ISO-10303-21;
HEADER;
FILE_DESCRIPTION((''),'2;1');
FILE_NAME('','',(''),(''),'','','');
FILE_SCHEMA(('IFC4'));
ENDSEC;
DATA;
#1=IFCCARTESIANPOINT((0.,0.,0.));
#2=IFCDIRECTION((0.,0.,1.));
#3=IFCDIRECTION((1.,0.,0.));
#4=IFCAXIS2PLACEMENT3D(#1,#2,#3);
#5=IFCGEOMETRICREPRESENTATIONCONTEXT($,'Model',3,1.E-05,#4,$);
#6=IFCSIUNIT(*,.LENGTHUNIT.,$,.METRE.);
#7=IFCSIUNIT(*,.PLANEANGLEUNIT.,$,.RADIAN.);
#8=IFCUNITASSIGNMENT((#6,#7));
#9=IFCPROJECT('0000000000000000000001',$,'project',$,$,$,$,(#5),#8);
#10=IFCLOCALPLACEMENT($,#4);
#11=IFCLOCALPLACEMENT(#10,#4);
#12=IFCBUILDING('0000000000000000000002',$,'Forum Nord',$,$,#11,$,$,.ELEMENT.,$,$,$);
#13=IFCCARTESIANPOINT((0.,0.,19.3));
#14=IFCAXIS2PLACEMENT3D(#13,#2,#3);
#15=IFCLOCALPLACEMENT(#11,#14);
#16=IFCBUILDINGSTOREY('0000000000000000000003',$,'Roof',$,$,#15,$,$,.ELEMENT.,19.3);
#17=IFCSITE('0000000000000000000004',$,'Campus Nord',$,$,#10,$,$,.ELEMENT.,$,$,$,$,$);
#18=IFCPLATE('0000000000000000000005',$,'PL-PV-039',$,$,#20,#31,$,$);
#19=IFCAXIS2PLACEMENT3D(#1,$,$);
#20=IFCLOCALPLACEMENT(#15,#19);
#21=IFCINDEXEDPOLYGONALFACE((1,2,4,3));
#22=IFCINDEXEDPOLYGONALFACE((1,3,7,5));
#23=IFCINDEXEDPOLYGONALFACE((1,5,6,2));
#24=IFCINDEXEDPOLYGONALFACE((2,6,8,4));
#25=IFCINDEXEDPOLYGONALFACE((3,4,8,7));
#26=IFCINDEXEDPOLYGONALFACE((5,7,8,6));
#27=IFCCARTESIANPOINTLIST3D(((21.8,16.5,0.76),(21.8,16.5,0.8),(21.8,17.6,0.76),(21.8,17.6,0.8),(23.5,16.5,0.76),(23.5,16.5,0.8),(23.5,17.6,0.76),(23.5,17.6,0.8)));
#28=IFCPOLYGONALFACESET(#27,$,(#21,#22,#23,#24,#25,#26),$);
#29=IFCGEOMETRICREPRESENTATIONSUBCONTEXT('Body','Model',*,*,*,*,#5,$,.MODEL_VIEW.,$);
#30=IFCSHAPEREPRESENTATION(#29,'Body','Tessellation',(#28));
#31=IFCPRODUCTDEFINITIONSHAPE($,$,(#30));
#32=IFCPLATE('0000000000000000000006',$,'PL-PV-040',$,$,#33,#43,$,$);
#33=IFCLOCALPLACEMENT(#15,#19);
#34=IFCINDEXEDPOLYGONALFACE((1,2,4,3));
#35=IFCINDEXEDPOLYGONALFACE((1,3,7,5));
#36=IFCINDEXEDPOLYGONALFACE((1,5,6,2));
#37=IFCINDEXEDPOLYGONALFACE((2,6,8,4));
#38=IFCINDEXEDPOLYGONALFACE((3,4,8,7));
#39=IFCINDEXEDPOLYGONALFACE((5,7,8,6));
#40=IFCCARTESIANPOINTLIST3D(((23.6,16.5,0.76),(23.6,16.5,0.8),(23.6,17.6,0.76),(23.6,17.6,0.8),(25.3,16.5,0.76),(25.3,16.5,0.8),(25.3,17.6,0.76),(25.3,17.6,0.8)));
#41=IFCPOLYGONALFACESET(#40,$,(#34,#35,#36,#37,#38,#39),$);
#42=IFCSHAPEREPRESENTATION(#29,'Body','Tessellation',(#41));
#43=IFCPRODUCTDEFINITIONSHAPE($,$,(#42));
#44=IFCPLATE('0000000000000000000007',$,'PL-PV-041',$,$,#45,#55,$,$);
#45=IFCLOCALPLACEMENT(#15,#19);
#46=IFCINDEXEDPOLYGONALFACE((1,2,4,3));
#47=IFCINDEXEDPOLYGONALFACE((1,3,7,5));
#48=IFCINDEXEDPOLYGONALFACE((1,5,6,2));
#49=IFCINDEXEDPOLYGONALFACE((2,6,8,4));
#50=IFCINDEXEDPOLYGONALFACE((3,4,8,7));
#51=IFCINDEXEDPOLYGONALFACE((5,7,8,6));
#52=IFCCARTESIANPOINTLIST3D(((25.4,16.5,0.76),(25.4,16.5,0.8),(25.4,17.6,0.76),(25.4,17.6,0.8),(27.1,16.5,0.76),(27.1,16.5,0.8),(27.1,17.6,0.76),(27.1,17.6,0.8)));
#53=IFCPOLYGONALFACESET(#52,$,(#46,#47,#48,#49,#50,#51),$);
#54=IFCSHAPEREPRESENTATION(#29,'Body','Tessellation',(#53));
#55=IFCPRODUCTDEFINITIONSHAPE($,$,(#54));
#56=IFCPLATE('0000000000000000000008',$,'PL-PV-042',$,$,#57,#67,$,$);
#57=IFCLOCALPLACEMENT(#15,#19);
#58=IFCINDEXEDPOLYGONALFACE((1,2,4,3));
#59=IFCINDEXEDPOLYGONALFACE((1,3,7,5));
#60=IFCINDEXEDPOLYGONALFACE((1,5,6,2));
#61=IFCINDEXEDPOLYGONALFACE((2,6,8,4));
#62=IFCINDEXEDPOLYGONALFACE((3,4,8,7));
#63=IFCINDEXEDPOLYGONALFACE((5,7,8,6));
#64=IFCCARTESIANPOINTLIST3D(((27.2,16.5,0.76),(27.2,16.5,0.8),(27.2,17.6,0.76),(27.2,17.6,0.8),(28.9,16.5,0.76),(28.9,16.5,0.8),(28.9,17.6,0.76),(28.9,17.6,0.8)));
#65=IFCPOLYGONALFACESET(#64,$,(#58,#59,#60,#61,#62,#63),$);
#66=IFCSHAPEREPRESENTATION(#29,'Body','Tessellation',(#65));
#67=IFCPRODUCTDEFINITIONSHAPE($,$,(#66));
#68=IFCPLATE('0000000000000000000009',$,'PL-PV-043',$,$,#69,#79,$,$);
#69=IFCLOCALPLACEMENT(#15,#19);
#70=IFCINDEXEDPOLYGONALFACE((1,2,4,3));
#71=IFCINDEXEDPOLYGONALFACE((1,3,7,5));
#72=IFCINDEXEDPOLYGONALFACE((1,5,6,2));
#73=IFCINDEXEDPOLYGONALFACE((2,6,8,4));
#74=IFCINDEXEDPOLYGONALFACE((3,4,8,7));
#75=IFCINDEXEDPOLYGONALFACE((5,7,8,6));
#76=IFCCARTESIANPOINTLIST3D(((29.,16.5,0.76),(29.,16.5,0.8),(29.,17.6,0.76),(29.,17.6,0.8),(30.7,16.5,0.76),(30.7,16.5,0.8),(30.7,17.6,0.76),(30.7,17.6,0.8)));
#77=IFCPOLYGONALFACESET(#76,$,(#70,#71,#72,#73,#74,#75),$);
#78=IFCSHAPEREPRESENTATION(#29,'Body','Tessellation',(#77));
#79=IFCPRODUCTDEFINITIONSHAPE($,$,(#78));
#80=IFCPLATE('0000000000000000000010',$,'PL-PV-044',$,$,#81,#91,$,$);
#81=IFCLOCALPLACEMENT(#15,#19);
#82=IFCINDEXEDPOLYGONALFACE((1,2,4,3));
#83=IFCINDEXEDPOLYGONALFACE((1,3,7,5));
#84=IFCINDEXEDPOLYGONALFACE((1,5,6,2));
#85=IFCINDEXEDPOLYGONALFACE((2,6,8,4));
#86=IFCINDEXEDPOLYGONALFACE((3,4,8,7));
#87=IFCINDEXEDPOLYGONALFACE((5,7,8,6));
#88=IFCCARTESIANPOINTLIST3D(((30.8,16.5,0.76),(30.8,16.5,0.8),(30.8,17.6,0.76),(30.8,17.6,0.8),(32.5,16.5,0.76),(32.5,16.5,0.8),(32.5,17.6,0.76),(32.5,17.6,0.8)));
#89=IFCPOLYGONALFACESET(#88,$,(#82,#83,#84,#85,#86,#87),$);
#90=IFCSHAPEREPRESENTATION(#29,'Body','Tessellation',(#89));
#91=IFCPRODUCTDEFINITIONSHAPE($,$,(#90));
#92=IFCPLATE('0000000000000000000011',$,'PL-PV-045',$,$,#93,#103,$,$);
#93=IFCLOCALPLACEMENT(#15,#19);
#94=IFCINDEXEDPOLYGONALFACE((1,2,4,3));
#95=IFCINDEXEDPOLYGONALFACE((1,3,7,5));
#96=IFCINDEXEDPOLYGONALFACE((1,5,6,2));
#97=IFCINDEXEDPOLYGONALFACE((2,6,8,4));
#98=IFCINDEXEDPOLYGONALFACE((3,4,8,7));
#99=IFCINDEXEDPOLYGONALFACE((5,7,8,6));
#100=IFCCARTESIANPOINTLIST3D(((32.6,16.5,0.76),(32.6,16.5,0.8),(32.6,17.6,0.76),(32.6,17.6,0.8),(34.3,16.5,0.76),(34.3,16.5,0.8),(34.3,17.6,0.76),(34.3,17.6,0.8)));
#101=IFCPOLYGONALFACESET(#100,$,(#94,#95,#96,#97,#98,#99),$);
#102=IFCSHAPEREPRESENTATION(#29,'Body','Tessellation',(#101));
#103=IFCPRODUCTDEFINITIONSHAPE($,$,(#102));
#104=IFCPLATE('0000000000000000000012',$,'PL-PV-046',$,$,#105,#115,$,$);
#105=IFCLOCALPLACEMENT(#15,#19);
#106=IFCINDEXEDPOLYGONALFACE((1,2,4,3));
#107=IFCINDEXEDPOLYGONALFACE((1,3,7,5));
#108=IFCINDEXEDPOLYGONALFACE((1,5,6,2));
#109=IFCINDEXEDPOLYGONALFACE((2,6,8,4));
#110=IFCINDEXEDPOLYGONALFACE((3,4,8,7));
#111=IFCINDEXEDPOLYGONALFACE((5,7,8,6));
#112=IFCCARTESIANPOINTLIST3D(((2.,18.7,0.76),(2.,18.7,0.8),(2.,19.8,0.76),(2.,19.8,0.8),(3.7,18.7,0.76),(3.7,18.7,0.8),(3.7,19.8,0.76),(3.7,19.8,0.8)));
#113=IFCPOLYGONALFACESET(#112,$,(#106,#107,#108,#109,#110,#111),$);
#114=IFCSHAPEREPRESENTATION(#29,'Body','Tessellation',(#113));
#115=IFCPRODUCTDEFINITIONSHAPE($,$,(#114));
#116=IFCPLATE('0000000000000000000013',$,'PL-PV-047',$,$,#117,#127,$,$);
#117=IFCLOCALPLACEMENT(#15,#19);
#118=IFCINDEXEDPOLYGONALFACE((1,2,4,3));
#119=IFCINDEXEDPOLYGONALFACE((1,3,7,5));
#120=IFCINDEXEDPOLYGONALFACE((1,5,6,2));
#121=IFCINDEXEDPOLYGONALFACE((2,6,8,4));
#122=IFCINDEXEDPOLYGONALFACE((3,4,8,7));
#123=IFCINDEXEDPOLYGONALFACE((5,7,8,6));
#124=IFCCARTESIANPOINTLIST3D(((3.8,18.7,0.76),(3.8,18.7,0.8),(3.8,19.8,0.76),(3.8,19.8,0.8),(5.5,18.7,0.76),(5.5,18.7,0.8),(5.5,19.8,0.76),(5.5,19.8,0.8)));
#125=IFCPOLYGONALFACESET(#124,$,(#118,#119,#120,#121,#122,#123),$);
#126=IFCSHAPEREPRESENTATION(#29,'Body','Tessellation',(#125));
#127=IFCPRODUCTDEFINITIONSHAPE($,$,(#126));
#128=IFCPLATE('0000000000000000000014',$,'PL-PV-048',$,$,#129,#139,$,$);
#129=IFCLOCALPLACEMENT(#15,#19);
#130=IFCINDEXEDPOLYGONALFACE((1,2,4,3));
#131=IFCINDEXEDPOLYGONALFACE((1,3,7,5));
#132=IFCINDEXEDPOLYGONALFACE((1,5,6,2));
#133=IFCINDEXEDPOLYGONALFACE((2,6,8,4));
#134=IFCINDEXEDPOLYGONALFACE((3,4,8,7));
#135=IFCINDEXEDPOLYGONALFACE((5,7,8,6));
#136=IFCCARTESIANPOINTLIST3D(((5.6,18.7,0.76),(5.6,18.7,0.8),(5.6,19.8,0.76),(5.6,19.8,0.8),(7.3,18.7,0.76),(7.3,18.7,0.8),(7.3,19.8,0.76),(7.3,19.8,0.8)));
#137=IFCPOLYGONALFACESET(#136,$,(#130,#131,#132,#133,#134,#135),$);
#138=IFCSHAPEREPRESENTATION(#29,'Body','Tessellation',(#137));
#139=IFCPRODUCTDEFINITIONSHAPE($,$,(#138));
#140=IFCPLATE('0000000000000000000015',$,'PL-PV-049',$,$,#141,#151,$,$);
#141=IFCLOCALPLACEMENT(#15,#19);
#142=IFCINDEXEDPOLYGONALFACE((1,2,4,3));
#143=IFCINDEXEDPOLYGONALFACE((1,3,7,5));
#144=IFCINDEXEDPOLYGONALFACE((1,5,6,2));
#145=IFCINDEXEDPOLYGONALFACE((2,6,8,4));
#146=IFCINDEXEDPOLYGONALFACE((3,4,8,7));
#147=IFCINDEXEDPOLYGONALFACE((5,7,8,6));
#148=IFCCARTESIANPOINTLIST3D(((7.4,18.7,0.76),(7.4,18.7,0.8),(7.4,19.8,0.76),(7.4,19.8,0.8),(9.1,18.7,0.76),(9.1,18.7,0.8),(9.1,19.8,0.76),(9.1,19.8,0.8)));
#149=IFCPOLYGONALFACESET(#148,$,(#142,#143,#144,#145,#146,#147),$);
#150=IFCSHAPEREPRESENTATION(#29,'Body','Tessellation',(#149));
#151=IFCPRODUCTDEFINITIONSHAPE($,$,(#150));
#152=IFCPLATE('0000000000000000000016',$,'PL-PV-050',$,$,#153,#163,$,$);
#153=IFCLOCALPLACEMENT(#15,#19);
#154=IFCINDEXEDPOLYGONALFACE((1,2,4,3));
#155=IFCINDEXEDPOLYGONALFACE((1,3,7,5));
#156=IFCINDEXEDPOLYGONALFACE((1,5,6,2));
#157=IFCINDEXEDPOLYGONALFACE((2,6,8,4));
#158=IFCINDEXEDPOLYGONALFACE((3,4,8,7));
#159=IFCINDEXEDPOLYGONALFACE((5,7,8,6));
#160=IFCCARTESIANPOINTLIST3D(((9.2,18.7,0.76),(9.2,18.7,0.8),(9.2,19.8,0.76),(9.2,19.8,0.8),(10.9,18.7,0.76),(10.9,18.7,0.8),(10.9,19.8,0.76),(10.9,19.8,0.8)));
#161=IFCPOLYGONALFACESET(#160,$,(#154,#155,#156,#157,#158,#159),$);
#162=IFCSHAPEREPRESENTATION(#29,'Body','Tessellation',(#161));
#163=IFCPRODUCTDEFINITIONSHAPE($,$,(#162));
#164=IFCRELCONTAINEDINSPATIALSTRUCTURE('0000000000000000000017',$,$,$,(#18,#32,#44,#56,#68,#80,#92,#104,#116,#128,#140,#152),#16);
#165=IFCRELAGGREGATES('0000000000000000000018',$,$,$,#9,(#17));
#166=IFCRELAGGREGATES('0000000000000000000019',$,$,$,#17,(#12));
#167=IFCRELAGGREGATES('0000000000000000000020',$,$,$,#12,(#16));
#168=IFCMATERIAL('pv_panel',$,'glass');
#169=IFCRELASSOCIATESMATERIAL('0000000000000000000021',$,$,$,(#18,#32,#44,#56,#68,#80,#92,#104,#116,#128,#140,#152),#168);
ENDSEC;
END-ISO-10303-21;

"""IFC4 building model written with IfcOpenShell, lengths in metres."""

from ifc_helpers import new_model, si_unit, frame, origin_with_axes, place, context, subcontext, project, spatial, polyline, outline, extrude, material, element, save


model = new_model("IFC4")

# Units and contexts
model_context = context("Model", 3, precision=1e-05, world=origin_with_axes())
body_context = subcontext(model_context, "Body", "Model", "MODEL_VIEW")
ifc_project = project(units=[si_unit("LENGTHUNIT", "METRE"), si_unit("PLANEANGLEUNIT", "RADIAN")], contexts=[model_context])

# Site, building, storey
site_placement = place(None, origin_with_axes())
site = spatial("IfcSite", under=ifc_project, at=site_placement, Name="Campus Nord", CompositionType="ELEMENT")
building_placement = place(site_placement, origin_with_axes())
building = spatial("IfcBuilding", under=site, at=building_placement, Name="Forum Nord", CompositionType="ELEMENT")
storey_placement = place(building_placement, frame((0.0, 0.0, 19.3), z_axis=(0.0, 0.0, 1.0), x_axis=(1.0, 0.0, 0.0)))
storey = spatial("IfcBuildingStorey", under=building, at=storey_placement, Name="Roof", CompositionType="ELEMENT", Elevation=19.3)

# Plates
ifc_material_1 = material(Name="pv_panel", Category="glass")
plate_1_placement = place(storey_placement, frame((0.0, 0.0, 0.8), z_axis=(0.0, 0.0, 1.0), x_axis=(1.0, 0.0, 0.0)))
element("IfcPlate", 1, at=plate_1_placement, inside=storey, material=ifc_material_1, Name="PL-PV-039", context=body_context, shape_type="SweptSolid", body=[
    extrude(outline(polyline([(21.8, 16.5), (23.5, 16.5), (23.5, 17.6), (21.8, 17.6), (21.8, 16.5)])), frame((0.0, 0.0, -0.04), z_axis=(0.0, 0.0, 1.0), x_axis=(1.0, 0.0, 0.0)), (0.0, 0.0, 1.0), 0.04),
])
plate_2_placement = place(storey_placement, frame((0.0, 0.0, 0.8), z_axis=(0.0, 0.0, 1.0), x_axis=(1.0, 0.0, 0.0)))
element("IfcPlate", 2, at=plate_2_placement, inside=storey, material=ifc_material_1, Name="PL-PV-040", context=body_context, shape_type="SweptSolid", body=[
    extrude(outline(polyline([(23.6, 16.5), (25.3, 16.5), (25.3, 17.6), (23.6, 17.6), (23.6, 16.5)])), frame((0.0, 0.0, -0.04), z_axis=(0.0, 0.0, 1.0), x_axis=(1.0, 0.0, 0.0)), (0.0, 0.0, 1.0), 0.04),
])
plate_3_placement = place(storey_placement, frame((0.0, 0.0, 0.8), z_axis=(0.0, 0.0, 1.0), x_axis=(1.0, 0.0, 0.0)))
element("IfcPlate", 3, at=plate_3_placement, inside=storey, material=ifc_material_1, Name="PL-PV-041", context=body_context, shape_type="SweptSolid", body=[
    extrude(outline(polyline([(25.4, 16.5), (27.1, 16.5), (27.1, 17.6), (25.4, 17.6), (25.4, 16.5)])), frame((0.0, 0.0, -0.04), z_axis=(0.0, 0.0, 1.0), x_axis=(1.0, 0.0, 0.0)), (0.0, 0.0, 1.0), 0.04),
])
plate_4_placement = place(storey_placement, frame((0.0, 0.0, 0.8), z_axis=(0.0, 0.0, 1.0), x_axis=(1.0, 0.0, 0.0)))
element("IfcPlate", 4, at=plate_4_placement, inside=storey, material=ifc_material_1, Name="PL-PV-042", context=body_context, shape_type="SweptSolid", body=[
    extrude(outline(polyline([(27.2, 16.5), (28.9, 16.5), (28.9, 17.6), (27.2, 17.6), (27.2, 16.5)])), frame((0.0, 0.0, -0.04), z_axis=(0.0, 0.0, 1.0), x_axis=(1.0, 0.0, 0.0)), (0.0, 0.0, 1.0), 0.04),
])
plate_5_placement = place(storey_placement, frame((0.0, 0.0, 0.8), z_axis=(0.0, 0.0, 1.0), x_axis=(1.0, 0.0, 0.0)))
element("IfcPlate", 5, at=plate_5_placement, inside=storey, material=ifc_material_1, Name="PL-PV-043", context=body_context, shape_type="SweptSolid", body=[
    extrude(outline(polyline([(29.0, 16.5), (30.7, 16.5), (30.7, 17.6), (29.0, 17.6), (29.0, 16.5)])), frame((0.0, 0.0, -0.04), z_axis=(0.0, 0.0, 1.0), x_axis=(1.0, 0.0, 0.0)), (0.0, 0.0, 1.0), 0.04),
])
plate_6_placement = place(storey_placement, frame((0.0, 0.0, 0.8), z_axis=(0.0, 0.0, 1.0), x_axis=(1.0, 0.0, 0.0)))
element("IfcPlate", 6, at=plate_6_placement, inside=storey, material=ifc_material_1, Name="PL-PV-044", context=body_context, shape_type="SweptSolid", body=[
    extrude(outline(polyline([(30.8, 16.5), (32.5, 16.5), (32.5, 17.6), (30.8, 17.6), (30.8, 16.5)])), frame((0.0, 0.0, -0.04), z_axis=(0.0, 0.0, 1.0), x_axis=(1.0, 0.0, 0.0)), (0.0, 0.0, 1.0), 0.04),
])
plate_7_placement = place(storey_placement, frame((0.0, 0.0, 0.8), z_axis=(0.0, 0.0, 1.0), x_axis=(1.0, 0.0, 0.0)))
element("IfcPlate", 7, at=plate_7_placement, inside=storey, material=ifc_material_1, Name="PL-PV-045", context=body_context, shape_type="SweptSolid", body=[
    extrude(outline(polyline([(32.6, 16.5), (34.3, 16.5), (34.3, 17.6), (32.6, 17.6), (32.6, 16.5)])), frame((0.0, 0.0, -0.04), z_axis=(0.0, 0.0, 1.0), x_axis=(1.0, 0.0, 0.0)), (0.0, 0.0, 1.0), 0.04),
])
plate_8_placement = place(storey_placement, frame((0.0, 0.0, 0.8), z_axis=(0.0, 0.0, 1.0), x_axis=(1.0, 0.0, 0.0)))
element("IfcPlate", 8, at=plate_8_placement, inside=storey, material=ifc_material_1, Name="PL-PV-046", context=body_context, shape_type="SweptSolid", body=[
    extrude(outline(polyline([(2.0, 18.7), (3.7, 18.7), (3.7, 19.8), (2.0, 19.8), (2.0, 18.7)])), frame((0.0, 0.0, -0.04), z_axis=(0.0, 0.0, 1.0), x_axis=(1.0, 0.0, 0.0)), (0.0, 0.0, 1.0), 0.04),
])
plate_9_placement = place(storey_placement, frame((0.0, 0.0, 0.8), z_axis=(0.0, 0.0, 1.0), x_axis=(1.0, 0.0, 0.0)))
element("IfcPlate", 9, at=plate_9_placement, inside=storey, material=ifc_material_1, Name="PL-PV-047", context=body_context, shape_type="SweptSolid", body=[
    extrude(outline(polyline([(3.8, 18.7), (5.5, 18.7), (5.5, 19.8), (3.8, 19.8), (3.8, 18.7)])), frame((0.0, 0.0, -0.04), z_axis=(0.0, 0.0, 1.0), x_axis=(1.0, 0.0, 0.0)), (0.0, 0.0, 1.0), 0.04),
])
plate_10_placement = place(storey_placement, frame((0.0, 0.0, 0.8), z_axis=(0.0, 0.0, 1.0), x_axis=(1.0, 0.0, 0.0)))
element("IfcPlate", 10, at=plate_10_placement, inside=storey, material=ifc_material_1, Name="PL-PV-048", context=body_context, shape_type="SweptSolid", body=[
    extrude(outline(polyline([(5.6, 18.7), (7.3, 18.7), (7.3, 19.8), (5.6, 19.8), (5.6, 18.7)])), frame((0.0, 0.0, -0.04), z_axis=(0.0, 0.0, 1.0), x_axis=(1.0, 0.0, 0.0)), (0.0, 0.0, 1.0), 0.04),
])
plate_11_placement = place(storey_placement, frame((0.0, 0.0, 0.8), z_axis=(0.0, 0.0, 1.0), x_axis=(1.0, 0.0, 0.0)))
element("IfcPlate", 11, at=plate_11_placement, inside=storey, material=ifc_material_1, Name="PL-PV-049", context=body_context, shape_type="SweptSolid", body=[
    extrude(outline(polyline([(7.4, 18.7), (9.1, 18.7), (9.1, 19.8), (7.4, 19.8), (7.4, 18.7)])), frame((0.0, 0.0, -0.04), z_axis=(0.0, 0.0, 1.0), x_axis=(1.0, 0.0, 0.0)), (0.0, 0.0, 1.0), 0.04),
])
plate_12_placement = place(storey_placement, frame((0.0, 0.0, 0.8), z_axis=(0.0, 0.0, 1.0), x_axis=(1.0, 0.0, 0.0)))
element("IfcPlate", 12, at=plate_12_placement, inside=storey, material=ifc_material_1, Name="PL-PV-050", context=body_context, shape_type="SweptSolid", body=[
    extrude(outline(polyline([(9.2, 18.7), (10.9, 18.7), (10.9, 19.8), (9.2, 19.8), (9.2, 18.7)])), frame((0.0, 0.0, -0.04), z_axis=(0.0, 0.0, 1.0), x_axis=(1.0, 0.0, 0.0)), (0.0, 0.0, 1.0), 0.04),
])

save(model, "model.ifc")
